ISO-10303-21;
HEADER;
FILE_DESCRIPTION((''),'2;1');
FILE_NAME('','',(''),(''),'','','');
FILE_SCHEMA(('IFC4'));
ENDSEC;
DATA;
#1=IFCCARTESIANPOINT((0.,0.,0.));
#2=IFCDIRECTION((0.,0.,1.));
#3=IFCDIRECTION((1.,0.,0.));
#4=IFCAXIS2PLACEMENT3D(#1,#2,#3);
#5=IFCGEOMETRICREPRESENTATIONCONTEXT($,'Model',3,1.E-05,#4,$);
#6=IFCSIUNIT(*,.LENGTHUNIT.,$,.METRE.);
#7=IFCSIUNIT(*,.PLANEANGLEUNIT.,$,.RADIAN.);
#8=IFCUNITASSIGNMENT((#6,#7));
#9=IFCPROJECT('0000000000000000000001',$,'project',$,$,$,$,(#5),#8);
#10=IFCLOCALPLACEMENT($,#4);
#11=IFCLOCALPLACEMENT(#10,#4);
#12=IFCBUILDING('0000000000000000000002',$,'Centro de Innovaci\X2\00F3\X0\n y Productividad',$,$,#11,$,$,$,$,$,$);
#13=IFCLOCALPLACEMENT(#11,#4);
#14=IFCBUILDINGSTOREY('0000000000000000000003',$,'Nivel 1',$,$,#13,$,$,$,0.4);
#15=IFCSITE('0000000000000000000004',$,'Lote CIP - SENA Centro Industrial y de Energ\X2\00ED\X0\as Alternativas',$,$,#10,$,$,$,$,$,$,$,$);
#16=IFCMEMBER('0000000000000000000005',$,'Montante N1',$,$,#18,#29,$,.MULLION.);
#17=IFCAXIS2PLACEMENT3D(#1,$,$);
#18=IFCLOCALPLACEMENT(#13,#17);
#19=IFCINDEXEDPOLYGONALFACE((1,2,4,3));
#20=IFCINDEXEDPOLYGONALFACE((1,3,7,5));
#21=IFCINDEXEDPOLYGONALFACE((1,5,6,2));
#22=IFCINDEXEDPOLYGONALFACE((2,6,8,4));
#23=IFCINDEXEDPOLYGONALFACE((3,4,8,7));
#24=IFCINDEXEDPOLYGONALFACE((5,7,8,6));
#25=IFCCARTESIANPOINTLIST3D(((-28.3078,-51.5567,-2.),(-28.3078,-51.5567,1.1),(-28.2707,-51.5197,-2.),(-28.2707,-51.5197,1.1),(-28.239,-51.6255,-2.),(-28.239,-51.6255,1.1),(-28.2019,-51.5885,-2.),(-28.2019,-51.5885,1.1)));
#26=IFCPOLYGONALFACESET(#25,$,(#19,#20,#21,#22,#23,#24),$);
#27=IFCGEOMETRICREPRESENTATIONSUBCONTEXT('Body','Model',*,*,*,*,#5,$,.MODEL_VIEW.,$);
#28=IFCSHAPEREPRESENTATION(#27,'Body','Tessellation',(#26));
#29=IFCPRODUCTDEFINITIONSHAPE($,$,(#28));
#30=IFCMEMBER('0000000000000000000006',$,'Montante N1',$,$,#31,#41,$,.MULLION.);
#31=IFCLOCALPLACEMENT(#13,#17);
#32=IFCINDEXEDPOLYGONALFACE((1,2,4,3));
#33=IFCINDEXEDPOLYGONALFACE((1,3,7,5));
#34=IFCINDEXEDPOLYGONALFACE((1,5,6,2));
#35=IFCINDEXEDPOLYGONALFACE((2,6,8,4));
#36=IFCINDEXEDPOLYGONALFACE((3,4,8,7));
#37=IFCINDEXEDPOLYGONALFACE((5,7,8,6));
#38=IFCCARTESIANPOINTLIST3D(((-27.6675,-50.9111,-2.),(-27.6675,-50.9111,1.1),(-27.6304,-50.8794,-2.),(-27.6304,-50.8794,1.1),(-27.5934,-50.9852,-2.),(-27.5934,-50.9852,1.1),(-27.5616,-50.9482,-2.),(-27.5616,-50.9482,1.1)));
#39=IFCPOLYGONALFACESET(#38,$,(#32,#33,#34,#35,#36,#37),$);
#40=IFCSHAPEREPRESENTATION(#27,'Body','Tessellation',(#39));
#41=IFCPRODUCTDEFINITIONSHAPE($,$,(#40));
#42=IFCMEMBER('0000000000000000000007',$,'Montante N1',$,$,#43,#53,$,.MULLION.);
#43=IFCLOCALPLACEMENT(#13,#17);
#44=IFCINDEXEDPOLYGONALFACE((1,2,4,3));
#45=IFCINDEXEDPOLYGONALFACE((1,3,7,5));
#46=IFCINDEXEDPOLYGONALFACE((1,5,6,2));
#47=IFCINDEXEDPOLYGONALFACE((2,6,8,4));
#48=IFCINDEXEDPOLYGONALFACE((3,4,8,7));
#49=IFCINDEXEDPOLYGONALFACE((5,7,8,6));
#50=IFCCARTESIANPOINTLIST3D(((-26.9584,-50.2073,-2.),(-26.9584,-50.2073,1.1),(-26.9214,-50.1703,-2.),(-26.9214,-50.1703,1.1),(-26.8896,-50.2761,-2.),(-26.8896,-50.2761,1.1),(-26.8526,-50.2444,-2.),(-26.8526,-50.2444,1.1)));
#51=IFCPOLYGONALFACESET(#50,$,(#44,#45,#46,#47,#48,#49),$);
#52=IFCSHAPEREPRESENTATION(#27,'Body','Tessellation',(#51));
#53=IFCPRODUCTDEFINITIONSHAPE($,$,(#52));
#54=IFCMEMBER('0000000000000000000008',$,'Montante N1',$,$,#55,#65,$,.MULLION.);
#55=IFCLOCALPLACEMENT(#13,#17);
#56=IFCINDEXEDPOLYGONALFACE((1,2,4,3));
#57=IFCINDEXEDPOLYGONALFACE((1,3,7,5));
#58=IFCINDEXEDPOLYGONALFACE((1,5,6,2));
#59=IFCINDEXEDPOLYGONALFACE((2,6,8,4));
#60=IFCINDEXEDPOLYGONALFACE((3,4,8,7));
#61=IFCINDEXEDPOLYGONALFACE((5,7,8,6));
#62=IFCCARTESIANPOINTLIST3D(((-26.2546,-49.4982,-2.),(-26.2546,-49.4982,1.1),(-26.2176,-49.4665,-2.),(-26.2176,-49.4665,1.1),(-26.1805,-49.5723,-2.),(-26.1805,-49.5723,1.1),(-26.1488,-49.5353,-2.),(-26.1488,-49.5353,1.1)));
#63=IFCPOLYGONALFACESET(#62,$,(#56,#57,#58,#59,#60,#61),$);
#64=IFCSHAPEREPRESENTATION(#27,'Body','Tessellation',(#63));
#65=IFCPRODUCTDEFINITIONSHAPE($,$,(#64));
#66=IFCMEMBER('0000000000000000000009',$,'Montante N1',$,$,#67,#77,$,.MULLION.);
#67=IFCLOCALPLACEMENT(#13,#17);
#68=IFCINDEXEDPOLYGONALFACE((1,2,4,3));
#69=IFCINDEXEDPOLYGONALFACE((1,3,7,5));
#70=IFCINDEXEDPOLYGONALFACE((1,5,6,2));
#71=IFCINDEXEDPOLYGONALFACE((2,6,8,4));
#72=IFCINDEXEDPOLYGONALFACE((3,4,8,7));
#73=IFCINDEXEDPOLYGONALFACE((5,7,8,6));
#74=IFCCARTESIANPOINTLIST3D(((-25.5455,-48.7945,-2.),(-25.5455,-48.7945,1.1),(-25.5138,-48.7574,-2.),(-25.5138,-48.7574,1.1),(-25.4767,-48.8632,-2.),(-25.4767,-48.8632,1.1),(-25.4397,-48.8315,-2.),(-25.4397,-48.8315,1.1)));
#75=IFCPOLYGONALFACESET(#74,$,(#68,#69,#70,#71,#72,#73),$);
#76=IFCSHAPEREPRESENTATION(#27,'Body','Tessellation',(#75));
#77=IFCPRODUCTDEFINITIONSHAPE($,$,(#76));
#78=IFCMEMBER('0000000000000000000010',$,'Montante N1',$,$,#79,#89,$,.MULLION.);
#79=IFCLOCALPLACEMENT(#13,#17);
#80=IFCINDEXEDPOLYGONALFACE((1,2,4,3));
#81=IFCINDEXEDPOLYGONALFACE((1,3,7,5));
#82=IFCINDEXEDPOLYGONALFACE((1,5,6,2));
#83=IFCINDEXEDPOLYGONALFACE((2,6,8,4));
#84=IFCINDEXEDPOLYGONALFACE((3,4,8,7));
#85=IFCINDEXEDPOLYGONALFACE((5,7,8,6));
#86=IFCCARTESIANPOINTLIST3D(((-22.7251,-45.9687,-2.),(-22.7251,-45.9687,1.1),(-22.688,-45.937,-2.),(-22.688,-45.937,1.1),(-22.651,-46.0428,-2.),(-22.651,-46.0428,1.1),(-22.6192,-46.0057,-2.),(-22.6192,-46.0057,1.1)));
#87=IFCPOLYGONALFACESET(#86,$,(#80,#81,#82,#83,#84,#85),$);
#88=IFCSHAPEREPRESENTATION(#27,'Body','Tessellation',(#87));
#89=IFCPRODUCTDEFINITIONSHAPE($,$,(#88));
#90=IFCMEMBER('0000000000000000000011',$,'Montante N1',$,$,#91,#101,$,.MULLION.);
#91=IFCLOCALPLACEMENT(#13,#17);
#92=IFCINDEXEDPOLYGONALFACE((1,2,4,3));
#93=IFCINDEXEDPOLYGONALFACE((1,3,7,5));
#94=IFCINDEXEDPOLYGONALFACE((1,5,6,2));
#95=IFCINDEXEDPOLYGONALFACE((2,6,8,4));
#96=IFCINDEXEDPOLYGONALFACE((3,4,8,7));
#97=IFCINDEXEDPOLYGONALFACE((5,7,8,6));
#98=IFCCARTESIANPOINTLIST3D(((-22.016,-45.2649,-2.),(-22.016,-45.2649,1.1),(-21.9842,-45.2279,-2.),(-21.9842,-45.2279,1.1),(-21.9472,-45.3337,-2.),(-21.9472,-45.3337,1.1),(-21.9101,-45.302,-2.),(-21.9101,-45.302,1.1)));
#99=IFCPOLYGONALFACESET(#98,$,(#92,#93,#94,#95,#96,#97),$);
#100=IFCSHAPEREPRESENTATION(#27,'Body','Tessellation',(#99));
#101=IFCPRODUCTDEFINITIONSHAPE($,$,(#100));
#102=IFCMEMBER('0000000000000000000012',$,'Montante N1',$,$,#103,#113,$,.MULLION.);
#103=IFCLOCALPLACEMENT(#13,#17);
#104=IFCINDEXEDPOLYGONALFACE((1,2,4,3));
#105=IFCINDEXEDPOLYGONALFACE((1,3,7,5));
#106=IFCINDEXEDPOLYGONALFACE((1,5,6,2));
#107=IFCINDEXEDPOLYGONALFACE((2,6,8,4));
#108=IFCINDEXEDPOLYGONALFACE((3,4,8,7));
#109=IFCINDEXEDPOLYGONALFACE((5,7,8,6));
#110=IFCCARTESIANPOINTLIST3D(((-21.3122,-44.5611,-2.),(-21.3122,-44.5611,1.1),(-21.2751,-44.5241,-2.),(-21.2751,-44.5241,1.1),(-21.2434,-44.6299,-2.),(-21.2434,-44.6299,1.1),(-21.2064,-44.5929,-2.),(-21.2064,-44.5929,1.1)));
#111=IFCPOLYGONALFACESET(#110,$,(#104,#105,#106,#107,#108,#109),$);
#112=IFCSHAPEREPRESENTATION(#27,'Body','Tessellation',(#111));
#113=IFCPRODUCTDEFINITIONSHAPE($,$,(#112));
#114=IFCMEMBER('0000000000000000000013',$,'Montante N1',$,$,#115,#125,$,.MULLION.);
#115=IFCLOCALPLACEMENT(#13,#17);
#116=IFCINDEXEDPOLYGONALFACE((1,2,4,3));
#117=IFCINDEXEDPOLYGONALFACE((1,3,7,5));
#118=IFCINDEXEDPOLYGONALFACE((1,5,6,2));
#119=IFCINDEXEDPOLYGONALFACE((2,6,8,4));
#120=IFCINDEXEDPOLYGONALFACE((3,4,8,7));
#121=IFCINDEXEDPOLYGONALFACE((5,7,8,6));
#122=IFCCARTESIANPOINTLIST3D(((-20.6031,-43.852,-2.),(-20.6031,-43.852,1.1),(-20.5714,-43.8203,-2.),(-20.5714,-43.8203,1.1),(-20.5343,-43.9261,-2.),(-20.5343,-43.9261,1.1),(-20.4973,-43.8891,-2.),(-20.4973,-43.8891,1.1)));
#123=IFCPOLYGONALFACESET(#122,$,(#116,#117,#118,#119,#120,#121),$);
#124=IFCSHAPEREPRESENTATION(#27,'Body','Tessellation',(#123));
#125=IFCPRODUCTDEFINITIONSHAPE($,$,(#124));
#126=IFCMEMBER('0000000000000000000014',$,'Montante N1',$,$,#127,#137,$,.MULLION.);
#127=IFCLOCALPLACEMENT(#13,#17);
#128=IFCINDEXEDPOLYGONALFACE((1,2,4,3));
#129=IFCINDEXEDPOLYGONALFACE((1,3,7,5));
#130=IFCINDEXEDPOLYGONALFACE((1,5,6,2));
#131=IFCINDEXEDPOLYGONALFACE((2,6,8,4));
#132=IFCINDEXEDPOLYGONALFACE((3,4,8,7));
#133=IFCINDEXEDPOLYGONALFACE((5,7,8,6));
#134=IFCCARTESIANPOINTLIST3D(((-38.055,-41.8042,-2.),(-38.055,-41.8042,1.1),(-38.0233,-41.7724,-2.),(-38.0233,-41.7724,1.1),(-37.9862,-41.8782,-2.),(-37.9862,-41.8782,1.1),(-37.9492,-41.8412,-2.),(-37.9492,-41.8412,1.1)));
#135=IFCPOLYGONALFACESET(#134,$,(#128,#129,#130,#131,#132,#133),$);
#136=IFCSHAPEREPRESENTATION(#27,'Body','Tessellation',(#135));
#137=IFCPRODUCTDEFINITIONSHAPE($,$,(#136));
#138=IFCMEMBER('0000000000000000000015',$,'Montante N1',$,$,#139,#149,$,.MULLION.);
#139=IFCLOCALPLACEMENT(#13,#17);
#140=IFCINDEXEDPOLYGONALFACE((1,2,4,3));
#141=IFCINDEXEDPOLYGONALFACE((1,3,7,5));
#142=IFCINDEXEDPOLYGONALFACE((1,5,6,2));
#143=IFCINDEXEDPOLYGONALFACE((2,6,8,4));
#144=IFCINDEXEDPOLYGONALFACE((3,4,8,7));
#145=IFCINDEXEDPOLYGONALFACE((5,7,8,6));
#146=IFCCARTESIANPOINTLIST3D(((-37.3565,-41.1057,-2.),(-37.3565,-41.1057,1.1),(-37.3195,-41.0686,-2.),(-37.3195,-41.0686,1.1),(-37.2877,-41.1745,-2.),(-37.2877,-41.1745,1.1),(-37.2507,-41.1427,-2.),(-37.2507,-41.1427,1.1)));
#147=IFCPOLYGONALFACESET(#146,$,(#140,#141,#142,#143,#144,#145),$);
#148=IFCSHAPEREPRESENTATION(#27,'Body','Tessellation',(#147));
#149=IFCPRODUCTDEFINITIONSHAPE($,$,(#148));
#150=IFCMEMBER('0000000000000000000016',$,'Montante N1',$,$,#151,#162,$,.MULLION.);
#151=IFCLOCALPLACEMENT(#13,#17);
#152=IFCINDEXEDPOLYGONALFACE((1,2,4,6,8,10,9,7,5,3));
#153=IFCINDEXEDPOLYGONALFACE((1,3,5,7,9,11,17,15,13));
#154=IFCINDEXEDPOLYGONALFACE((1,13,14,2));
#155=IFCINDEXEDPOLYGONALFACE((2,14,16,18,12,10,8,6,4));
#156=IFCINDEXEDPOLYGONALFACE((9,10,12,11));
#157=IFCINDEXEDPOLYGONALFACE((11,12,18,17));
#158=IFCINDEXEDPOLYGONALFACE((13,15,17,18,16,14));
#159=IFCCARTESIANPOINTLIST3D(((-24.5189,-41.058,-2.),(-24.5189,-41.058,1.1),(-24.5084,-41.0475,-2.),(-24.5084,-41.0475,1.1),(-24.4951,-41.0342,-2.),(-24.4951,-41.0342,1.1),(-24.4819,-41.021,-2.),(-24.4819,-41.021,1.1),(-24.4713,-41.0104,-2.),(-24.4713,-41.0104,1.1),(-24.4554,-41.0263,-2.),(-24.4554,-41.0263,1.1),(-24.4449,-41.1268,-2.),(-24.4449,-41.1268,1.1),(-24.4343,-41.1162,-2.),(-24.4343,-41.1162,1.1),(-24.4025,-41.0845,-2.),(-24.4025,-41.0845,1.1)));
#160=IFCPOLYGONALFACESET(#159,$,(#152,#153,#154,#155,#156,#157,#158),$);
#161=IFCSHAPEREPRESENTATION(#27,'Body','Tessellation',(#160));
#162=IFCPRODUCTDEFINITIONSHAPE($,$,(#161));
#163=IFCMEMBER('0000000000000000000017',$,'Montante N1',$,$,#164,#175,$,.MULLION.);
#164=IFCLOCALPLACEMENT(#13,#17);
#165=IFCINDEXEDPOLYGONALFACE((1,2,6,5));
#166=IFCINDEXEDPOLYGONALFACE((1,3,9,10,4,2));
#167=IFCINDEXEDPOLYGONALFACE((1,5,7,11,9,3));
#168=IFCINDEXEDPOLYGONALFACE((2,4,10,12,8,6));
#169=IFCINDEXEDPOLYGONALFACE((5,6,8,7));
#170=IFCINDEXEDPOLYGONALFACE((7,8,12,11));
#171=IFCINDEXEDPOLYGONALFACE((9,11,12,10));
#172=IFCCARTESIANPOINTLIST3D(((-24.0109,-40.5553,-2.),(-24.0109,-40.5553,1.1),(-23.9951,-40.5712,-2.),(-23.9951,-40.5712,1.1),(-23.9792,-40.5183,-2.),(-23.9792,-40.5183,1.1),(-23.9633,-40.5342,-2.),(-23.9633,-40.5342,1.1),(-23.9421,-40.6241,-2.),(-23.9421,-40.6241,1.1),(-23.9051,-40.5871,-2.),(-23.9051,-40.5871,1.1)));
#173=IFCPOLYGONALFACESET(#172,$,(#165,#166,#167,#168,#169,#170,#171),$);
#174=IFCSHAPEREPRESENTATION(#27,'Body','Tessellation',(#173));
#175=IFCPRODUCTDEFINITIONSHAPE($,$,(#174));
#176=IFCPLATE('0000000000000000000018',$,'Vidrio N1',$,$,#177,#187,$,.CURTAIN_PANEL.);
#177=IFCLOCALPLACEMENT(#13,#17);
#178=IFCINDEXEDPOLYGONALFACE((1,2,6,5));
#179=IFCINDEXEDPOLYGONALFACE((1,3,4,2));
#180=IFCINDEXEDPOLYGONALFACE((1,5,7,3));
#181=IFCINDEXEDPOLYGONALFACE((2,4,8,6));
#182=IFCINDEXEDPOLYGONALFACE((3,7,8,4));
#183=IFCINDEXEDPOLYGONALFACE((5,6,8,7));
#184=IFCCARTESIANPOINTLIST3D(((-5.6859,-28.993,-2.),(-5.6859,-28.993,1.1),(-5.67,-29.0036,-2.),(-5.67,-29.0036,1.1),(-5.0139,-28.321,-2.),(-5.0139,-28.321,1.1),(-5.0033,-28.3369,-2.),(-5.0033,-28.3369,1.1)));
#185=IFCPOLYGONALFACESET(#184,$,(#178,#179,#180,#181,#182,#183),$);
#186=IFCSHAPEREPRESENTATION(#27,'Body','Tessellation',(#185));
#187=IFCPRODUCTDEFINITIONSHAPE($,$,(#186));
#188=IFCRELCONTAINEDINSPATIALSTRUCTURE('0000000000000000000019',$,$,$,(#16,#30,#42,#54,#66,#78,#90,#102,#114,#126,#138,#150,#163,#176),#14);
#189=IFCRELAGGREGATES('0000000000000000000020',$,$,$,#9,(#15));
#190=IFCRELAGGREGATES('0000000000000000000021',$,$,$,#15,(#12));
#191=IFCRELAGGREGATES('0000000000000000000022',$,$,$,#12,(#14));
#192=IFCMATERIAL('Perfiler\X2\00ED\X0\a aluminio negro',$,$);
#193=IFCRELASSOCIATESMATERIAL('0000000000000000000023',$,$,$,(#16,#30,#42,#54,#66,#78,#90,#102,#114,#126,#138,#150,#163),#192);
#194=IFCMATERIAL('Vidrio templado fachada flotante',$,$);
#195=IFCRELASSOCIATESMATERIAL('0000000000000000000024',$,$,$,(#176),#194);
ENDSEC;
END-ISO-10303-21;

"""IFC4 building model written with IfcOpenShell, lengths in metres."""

from ifc_helpers import new_model, si_unit, frame, origin_with_axes, place, context, subcontext, project, spatial, polyline, outline, extrude, material, element, save


model = new_model("IFC4")

# Units and contexts
model_context = context("Model", 3, precision=1e-05, world=origin_with_axes())
body_context = subcontext(model_context, "Body", "Model", "MODEL_VIEW")
ifc_project = project(units=[si_unit("LENGTHUNIT", "METRE"), si_unit("PLANEANGLEUNIT", "RADIAN")], contexts=[model_context])

# Site, building, storey
site_placement = place(None, origin_with_axes())
site = spatial("IfcSite", under=ifc_project, at=site_placement, Name="Lote CIP - SENA Centro Industrial y de Energías Alternativas")
building_placement = place(site_placement, origin_with_axes())
building = spatial("IfcBuilding", under=site, at=building_placement, Name="Centro de Innovación y Productividad")
storey_placement = place(building_placement, origin_with_axes())
storey = spatial("IfcBuildingStorey", under=building, at=storey_placement, Name="Nivel 1", Elevation=0.4)

# Members
ifc_material_1 = material(Name="Perfilería aluminio negro")
member_1_placement = place(storey_placement, frame((0.0, 0.0, -2.4), z_axis=(0.0, 0.0, 1.0), x_axis=(1.0, 0.0, 0.0)))
element("IfcMember", 1, at=member_1_placement, inside=storey, material=ifc_material_1, Name="Montante N1", PredefinedType="MULLION", context=body_context, shape_type="SweptSolid", body=[
    extrude(outline(polyline([(-28.2707, -51.5197), (-28.2019, -51.5885), (-28.239, -51.6255), (-28.3078, -51.5567), (-28.2707, -51.5197)])), frame((0.0, 0.0, 0.4)), (0.0, 0.0, 1.0), 3.1),
])
member_2_placement = place(storey_placement, frame((0.0, 0.0, -2.4), z_axis=(0.0, 0.0, 1.0), x_axis=(1.0, 0.0, 0.0)))
element("IfcMember", 2, at=member_2_placement, inside=storey, material=ifc_material_1, Name="Montante N1", PredefinedType="MULLION", context=body_context, shape_type="SweptSolid", body=[
    extrude(outline(polyline([(-27.6304, -50.8794), (-27.5616, -50.9482), (-27.5934, -50.9852), (-27.6675, -50.9111), (-27.6304, -50.8794)])), frame((0.0, 0.0, 0.4)), (0.0, 0.0, 1.0), 3.1),
])
member_3_placement = place(storey_placement, frame((0.0, 0.0, -2.4), z_axis=(0.0, 0.0, 1.0), x_axis=(1.0, 0.0, 0.0)))
element("IfcMember", 3, at=member_3_placement, inside=storey, material=ifc_material_1, Name="Montante N1", PredefinedType="MULLION", context=body_context, shape_type="SweptSolid", body=[
    extrude(outline(polyline([(-26.9584, -50.2073), (-26.9214, -50.1703), (-26.8526, -50.2444), (-26.8896, -50.2761), (-26.9584, -50.2073)])), frame((0.0, 0.0, 0.4)), (0.0, 0.0, 1.0), 3.1),
])
member_4_placement = place(storey_placement, frame((0.0, 0.0, -2.4), z_axis=(0.0, 0.0, 1.0), x_axis=(1.0, 0.0, 0.0)))
element("IfcMember", 4, at=member_4_placement, inside=storey, material=ifc_material_1, Name="Montante N1", PredefinedType="MULLION", context=body_context, shape_type="SweptSolid", body=[
    extrude(outline(polyline([(-26.2546, -49.4982), (-26.2176, -49.4665), (-26.1488, -49.5353), (-26.1805, -49.5723), (-26.2546, -49.4982)])), frame((0.0, 0.0, 0.4)), (0.0, 0.0, 1.0), 3.1),
])
member_5_placement = place(storey_placement, frame((0.0, 0.0, -2.4), z_axis=(0.0, 0.0, 1.0), x_axis=(1.0, 0.0, 0.0)))
element("IfcMember", 5, at=member_5_placement, inside=storey, material=ifc_material_1, Name="Montante N1", PredefinedType="MULLION", context=body_context, shape_type="SweptSolid", body=[
    extrude(outline(polyline([(-25.5138, -48.7574), (-25.4397, -48.8315), (-25.4767, -48.8632), (-25.5455, -48.7945), (-25.5138, -48.7574)])), frame((0.0, 0.0, 0.4)), (0.0, 0.0, 1.0), 3.1),
])
member_6_placement = place(storey_placement, frame((0.0, 0.0, -2.4), z_axis=(0.0, 0.0, 1.0), x_axis=(1.0, 0.0, 0.0)))
element("IfcMember", 6, at=member_6_placement, inside=storey, material=ifc_material_1, Name="Montante N1", PredefinedType="MULLION", context=body_context, shape_type="SweptSolid", body=[
    extrude(outline(polyline([(-22.7251, -45.9687), (-22.688, -45.937), (-22.6192, -46.0057), (-22.651, -46.0428), (-22.7251, -45.9687)])), frame((0.0, 0.0, 0.4)), (0.0, 0.0, 1.0), 3.1),
])
member_7_placement = place(storey_placement, frame((0.0, 0.0, -2.4), z_axis=(0.0, 0.0, 1.0), x_axis=(1.0, 0.0, 0.0)))
element("IfcMember", 7, at=member_7_placement, inside=storey, material=ifc_material_1, Name="Montante N1", PredefinedType="MULLION", context=body_context, shape_type="SweptSolid", body=[
    extrude(outline(polyline([(-22.016, -45.2649), (-21.9842, -45.2279), (-21.9101, -45.302), (-21.9472, -45.3337), (-22.016, -45.2649)])), frame((0.0, 0.0, 0.4)), (0.0, 0.0, 1.0), 3.1),
])
member_8_placement = place(storey_placement, frame((0.0, 0.0, -2.4), z_axis=(0.0, 0.0, 1.0), x_axis=(1.0, 0.0, 0.0)))
element("IfcMember", 8, at=member_8_placement, inside=storey, material=ifc_material_1, Name="Montante N1", PredefinedType="MULLION", context=body_context, shape_type="SweptSolid", body=[
    extrude(outline(polyline([(-21.2751, -44.5241), (-21.2064, -44.5929), (-21.2434, -44.6299), (-21.3122, -44.5611), (-21.2751, -44.5241)])), frame((0.0, 0.0, 0.4)), (0.0, 0.0, 1.0), 3.1),
])
member_9_placement = place(storey_placement, frame((0.0, 0.0, -2.4), z_axis=(0.0, 0.0, 1.0), x_axis=(1.0, 0.0, 0.0)))
element("IfcMember", 9, at=member_9_placement, inside=storey, material=ifc_material_1, Name="Montante N1", PredefinedType="MULLION", context=body_context, shape_type="SweptSolid", body=[
    extrude(outline(polyline([(-20.5714, -43.8203), (-20.4973, -43.8891), (-20.5343, -43.9261), (-20.6031, -43.852), (-20.5714, -43.8203)])), frame((0.0, 0.0, 0.4)), (0.0, 0.0, 1.0), 3.1),
])
member_10_placement = place(storey_placement, frame((0.0, 0.0, -2.4), z_axis=(0.0, 0.0, 1.0), x_axis=(1.0, 0.0, 0.0)))
element("IfcMember", 10, at=member_10_placement, inside=storey, material=ifc_material_1, Name="Montante N1", PredefinedType="MULLION", context=body_context, shape_type="SweptSolid", body=[
    extrude(outline(polyline([(-37.9862, -41.8783), (-38.055, -41.8042), (-38.0233, -41.7724), (-37.9492, -41.8412), (-37.9862, -41.8783)])), frame((0.0, 0.0, 0.4)), (0.0, 0.0, 1.0), 3.1),
])
member_11_placement = place(storey_placement, frame((0.0, 0.0, -2.4), z_axis=(0.0, 0.0, 1.0), x_axis=(1.0, 0.0, 0.0)))
element("IfcMember", 11, at=member_11_placement, inside=storey, material=ifc_material_1, Name="Montante N1", PredefinedType="MULLION", context=body_context, shape_type="SweptSolid", body=[
    extrude(outline(polyline([(-37.2877, -41.1745), (-37.3565, -41.1057), (-37.3195, -41.0686), (-37.2507, -41.1427), (-37.2877, -41.1745)])), frame((0.0, 0.0, 0.4)), (0.0, 0.0, 1.0), 3.1),
])
member_12_placement = place(storey_placement, frame((0.0, 0.0, -2.4), z_axis=(0.0, 0.0, 1.0), x_axis=(1.0, 0.0, 0.0)))
element("IfcMember", 12, at=member_12_placement, inside=storey, material=ifc_material_1, Name="Montante N1", PredefinedType="MULLION", context=body_context, shape_type="SweptSolid", body=[
    extrude(outline(polyline([(-24.4343, -41.1162), (-24.4343, -41.1162), (-24.4449, -41.1268), (-24.5189, -41.058), (-24.5084, -41.0475), (-24.4951, -41.0342), (-24.4819, -41.021), (-24.4713, -41.0104), (-24.4554, -41.0263), (-24.4025, -41.0845), (-24.4343, -41.1162)])), frame((0.0, 0.0, 0.4)), (0.0, 0.0, 1.0), 3.1),
])
member_13_placement = place(storey_placement, frame((0.0, 0.0, -2.4), z_axis=(0.0, 0.0, 1.0), x_axis=(1.0, 0.0, 0.0)))
element("IfcMember", 13, at=member_13_placement, inside=storey, material=ifc_material_1, Name="Montante N1", PredefinedType="MULLION", context=body_context, shape_type="SweptSolid", body=[
    extrude(outline(polyline([(-23.9421, -40.6241), (-23.9951, -40.5712), (-24.0109, -40.5553), (-23.9792, -40.5183), (-23.9633, -40.5342), (-23.9051, -40.5871), (-23.9421, -40.6241)])), frame((0.0, 0.0, 0.4)), (0.0, 0.0, 1.0), 3.1),
])

# Plate
ifc_material_2 = material(Name="Vidrio templado fachada flotante")
plate_1_placement = place(storey_placement, frame((0.0, 0.0, -2.4), z_axis=(0.0, 0.0, 1.0), x_axis=(1.0, 0.0, 0.0)))
element("IfcPlate", 14, at=plate_1_placement, inside=storey, material=ifc_material_2, Name="Vidrio N1", PredefinedType="CURTAIN_PANEL", context=body_context, shape_type="SweptSolid", body=[
    extrude(outline(polyline([(-5.0033, -28.3369), (-5.67, -29.0036), (-5.6859, -28.993), (-5.0139, -28.321), (-5.0033, -28.3369)])), frame((0.0, 0.0, 0.4)), (0.0, 0.0, 1.0), 3.1),
])

save(model, "model.ifc")
